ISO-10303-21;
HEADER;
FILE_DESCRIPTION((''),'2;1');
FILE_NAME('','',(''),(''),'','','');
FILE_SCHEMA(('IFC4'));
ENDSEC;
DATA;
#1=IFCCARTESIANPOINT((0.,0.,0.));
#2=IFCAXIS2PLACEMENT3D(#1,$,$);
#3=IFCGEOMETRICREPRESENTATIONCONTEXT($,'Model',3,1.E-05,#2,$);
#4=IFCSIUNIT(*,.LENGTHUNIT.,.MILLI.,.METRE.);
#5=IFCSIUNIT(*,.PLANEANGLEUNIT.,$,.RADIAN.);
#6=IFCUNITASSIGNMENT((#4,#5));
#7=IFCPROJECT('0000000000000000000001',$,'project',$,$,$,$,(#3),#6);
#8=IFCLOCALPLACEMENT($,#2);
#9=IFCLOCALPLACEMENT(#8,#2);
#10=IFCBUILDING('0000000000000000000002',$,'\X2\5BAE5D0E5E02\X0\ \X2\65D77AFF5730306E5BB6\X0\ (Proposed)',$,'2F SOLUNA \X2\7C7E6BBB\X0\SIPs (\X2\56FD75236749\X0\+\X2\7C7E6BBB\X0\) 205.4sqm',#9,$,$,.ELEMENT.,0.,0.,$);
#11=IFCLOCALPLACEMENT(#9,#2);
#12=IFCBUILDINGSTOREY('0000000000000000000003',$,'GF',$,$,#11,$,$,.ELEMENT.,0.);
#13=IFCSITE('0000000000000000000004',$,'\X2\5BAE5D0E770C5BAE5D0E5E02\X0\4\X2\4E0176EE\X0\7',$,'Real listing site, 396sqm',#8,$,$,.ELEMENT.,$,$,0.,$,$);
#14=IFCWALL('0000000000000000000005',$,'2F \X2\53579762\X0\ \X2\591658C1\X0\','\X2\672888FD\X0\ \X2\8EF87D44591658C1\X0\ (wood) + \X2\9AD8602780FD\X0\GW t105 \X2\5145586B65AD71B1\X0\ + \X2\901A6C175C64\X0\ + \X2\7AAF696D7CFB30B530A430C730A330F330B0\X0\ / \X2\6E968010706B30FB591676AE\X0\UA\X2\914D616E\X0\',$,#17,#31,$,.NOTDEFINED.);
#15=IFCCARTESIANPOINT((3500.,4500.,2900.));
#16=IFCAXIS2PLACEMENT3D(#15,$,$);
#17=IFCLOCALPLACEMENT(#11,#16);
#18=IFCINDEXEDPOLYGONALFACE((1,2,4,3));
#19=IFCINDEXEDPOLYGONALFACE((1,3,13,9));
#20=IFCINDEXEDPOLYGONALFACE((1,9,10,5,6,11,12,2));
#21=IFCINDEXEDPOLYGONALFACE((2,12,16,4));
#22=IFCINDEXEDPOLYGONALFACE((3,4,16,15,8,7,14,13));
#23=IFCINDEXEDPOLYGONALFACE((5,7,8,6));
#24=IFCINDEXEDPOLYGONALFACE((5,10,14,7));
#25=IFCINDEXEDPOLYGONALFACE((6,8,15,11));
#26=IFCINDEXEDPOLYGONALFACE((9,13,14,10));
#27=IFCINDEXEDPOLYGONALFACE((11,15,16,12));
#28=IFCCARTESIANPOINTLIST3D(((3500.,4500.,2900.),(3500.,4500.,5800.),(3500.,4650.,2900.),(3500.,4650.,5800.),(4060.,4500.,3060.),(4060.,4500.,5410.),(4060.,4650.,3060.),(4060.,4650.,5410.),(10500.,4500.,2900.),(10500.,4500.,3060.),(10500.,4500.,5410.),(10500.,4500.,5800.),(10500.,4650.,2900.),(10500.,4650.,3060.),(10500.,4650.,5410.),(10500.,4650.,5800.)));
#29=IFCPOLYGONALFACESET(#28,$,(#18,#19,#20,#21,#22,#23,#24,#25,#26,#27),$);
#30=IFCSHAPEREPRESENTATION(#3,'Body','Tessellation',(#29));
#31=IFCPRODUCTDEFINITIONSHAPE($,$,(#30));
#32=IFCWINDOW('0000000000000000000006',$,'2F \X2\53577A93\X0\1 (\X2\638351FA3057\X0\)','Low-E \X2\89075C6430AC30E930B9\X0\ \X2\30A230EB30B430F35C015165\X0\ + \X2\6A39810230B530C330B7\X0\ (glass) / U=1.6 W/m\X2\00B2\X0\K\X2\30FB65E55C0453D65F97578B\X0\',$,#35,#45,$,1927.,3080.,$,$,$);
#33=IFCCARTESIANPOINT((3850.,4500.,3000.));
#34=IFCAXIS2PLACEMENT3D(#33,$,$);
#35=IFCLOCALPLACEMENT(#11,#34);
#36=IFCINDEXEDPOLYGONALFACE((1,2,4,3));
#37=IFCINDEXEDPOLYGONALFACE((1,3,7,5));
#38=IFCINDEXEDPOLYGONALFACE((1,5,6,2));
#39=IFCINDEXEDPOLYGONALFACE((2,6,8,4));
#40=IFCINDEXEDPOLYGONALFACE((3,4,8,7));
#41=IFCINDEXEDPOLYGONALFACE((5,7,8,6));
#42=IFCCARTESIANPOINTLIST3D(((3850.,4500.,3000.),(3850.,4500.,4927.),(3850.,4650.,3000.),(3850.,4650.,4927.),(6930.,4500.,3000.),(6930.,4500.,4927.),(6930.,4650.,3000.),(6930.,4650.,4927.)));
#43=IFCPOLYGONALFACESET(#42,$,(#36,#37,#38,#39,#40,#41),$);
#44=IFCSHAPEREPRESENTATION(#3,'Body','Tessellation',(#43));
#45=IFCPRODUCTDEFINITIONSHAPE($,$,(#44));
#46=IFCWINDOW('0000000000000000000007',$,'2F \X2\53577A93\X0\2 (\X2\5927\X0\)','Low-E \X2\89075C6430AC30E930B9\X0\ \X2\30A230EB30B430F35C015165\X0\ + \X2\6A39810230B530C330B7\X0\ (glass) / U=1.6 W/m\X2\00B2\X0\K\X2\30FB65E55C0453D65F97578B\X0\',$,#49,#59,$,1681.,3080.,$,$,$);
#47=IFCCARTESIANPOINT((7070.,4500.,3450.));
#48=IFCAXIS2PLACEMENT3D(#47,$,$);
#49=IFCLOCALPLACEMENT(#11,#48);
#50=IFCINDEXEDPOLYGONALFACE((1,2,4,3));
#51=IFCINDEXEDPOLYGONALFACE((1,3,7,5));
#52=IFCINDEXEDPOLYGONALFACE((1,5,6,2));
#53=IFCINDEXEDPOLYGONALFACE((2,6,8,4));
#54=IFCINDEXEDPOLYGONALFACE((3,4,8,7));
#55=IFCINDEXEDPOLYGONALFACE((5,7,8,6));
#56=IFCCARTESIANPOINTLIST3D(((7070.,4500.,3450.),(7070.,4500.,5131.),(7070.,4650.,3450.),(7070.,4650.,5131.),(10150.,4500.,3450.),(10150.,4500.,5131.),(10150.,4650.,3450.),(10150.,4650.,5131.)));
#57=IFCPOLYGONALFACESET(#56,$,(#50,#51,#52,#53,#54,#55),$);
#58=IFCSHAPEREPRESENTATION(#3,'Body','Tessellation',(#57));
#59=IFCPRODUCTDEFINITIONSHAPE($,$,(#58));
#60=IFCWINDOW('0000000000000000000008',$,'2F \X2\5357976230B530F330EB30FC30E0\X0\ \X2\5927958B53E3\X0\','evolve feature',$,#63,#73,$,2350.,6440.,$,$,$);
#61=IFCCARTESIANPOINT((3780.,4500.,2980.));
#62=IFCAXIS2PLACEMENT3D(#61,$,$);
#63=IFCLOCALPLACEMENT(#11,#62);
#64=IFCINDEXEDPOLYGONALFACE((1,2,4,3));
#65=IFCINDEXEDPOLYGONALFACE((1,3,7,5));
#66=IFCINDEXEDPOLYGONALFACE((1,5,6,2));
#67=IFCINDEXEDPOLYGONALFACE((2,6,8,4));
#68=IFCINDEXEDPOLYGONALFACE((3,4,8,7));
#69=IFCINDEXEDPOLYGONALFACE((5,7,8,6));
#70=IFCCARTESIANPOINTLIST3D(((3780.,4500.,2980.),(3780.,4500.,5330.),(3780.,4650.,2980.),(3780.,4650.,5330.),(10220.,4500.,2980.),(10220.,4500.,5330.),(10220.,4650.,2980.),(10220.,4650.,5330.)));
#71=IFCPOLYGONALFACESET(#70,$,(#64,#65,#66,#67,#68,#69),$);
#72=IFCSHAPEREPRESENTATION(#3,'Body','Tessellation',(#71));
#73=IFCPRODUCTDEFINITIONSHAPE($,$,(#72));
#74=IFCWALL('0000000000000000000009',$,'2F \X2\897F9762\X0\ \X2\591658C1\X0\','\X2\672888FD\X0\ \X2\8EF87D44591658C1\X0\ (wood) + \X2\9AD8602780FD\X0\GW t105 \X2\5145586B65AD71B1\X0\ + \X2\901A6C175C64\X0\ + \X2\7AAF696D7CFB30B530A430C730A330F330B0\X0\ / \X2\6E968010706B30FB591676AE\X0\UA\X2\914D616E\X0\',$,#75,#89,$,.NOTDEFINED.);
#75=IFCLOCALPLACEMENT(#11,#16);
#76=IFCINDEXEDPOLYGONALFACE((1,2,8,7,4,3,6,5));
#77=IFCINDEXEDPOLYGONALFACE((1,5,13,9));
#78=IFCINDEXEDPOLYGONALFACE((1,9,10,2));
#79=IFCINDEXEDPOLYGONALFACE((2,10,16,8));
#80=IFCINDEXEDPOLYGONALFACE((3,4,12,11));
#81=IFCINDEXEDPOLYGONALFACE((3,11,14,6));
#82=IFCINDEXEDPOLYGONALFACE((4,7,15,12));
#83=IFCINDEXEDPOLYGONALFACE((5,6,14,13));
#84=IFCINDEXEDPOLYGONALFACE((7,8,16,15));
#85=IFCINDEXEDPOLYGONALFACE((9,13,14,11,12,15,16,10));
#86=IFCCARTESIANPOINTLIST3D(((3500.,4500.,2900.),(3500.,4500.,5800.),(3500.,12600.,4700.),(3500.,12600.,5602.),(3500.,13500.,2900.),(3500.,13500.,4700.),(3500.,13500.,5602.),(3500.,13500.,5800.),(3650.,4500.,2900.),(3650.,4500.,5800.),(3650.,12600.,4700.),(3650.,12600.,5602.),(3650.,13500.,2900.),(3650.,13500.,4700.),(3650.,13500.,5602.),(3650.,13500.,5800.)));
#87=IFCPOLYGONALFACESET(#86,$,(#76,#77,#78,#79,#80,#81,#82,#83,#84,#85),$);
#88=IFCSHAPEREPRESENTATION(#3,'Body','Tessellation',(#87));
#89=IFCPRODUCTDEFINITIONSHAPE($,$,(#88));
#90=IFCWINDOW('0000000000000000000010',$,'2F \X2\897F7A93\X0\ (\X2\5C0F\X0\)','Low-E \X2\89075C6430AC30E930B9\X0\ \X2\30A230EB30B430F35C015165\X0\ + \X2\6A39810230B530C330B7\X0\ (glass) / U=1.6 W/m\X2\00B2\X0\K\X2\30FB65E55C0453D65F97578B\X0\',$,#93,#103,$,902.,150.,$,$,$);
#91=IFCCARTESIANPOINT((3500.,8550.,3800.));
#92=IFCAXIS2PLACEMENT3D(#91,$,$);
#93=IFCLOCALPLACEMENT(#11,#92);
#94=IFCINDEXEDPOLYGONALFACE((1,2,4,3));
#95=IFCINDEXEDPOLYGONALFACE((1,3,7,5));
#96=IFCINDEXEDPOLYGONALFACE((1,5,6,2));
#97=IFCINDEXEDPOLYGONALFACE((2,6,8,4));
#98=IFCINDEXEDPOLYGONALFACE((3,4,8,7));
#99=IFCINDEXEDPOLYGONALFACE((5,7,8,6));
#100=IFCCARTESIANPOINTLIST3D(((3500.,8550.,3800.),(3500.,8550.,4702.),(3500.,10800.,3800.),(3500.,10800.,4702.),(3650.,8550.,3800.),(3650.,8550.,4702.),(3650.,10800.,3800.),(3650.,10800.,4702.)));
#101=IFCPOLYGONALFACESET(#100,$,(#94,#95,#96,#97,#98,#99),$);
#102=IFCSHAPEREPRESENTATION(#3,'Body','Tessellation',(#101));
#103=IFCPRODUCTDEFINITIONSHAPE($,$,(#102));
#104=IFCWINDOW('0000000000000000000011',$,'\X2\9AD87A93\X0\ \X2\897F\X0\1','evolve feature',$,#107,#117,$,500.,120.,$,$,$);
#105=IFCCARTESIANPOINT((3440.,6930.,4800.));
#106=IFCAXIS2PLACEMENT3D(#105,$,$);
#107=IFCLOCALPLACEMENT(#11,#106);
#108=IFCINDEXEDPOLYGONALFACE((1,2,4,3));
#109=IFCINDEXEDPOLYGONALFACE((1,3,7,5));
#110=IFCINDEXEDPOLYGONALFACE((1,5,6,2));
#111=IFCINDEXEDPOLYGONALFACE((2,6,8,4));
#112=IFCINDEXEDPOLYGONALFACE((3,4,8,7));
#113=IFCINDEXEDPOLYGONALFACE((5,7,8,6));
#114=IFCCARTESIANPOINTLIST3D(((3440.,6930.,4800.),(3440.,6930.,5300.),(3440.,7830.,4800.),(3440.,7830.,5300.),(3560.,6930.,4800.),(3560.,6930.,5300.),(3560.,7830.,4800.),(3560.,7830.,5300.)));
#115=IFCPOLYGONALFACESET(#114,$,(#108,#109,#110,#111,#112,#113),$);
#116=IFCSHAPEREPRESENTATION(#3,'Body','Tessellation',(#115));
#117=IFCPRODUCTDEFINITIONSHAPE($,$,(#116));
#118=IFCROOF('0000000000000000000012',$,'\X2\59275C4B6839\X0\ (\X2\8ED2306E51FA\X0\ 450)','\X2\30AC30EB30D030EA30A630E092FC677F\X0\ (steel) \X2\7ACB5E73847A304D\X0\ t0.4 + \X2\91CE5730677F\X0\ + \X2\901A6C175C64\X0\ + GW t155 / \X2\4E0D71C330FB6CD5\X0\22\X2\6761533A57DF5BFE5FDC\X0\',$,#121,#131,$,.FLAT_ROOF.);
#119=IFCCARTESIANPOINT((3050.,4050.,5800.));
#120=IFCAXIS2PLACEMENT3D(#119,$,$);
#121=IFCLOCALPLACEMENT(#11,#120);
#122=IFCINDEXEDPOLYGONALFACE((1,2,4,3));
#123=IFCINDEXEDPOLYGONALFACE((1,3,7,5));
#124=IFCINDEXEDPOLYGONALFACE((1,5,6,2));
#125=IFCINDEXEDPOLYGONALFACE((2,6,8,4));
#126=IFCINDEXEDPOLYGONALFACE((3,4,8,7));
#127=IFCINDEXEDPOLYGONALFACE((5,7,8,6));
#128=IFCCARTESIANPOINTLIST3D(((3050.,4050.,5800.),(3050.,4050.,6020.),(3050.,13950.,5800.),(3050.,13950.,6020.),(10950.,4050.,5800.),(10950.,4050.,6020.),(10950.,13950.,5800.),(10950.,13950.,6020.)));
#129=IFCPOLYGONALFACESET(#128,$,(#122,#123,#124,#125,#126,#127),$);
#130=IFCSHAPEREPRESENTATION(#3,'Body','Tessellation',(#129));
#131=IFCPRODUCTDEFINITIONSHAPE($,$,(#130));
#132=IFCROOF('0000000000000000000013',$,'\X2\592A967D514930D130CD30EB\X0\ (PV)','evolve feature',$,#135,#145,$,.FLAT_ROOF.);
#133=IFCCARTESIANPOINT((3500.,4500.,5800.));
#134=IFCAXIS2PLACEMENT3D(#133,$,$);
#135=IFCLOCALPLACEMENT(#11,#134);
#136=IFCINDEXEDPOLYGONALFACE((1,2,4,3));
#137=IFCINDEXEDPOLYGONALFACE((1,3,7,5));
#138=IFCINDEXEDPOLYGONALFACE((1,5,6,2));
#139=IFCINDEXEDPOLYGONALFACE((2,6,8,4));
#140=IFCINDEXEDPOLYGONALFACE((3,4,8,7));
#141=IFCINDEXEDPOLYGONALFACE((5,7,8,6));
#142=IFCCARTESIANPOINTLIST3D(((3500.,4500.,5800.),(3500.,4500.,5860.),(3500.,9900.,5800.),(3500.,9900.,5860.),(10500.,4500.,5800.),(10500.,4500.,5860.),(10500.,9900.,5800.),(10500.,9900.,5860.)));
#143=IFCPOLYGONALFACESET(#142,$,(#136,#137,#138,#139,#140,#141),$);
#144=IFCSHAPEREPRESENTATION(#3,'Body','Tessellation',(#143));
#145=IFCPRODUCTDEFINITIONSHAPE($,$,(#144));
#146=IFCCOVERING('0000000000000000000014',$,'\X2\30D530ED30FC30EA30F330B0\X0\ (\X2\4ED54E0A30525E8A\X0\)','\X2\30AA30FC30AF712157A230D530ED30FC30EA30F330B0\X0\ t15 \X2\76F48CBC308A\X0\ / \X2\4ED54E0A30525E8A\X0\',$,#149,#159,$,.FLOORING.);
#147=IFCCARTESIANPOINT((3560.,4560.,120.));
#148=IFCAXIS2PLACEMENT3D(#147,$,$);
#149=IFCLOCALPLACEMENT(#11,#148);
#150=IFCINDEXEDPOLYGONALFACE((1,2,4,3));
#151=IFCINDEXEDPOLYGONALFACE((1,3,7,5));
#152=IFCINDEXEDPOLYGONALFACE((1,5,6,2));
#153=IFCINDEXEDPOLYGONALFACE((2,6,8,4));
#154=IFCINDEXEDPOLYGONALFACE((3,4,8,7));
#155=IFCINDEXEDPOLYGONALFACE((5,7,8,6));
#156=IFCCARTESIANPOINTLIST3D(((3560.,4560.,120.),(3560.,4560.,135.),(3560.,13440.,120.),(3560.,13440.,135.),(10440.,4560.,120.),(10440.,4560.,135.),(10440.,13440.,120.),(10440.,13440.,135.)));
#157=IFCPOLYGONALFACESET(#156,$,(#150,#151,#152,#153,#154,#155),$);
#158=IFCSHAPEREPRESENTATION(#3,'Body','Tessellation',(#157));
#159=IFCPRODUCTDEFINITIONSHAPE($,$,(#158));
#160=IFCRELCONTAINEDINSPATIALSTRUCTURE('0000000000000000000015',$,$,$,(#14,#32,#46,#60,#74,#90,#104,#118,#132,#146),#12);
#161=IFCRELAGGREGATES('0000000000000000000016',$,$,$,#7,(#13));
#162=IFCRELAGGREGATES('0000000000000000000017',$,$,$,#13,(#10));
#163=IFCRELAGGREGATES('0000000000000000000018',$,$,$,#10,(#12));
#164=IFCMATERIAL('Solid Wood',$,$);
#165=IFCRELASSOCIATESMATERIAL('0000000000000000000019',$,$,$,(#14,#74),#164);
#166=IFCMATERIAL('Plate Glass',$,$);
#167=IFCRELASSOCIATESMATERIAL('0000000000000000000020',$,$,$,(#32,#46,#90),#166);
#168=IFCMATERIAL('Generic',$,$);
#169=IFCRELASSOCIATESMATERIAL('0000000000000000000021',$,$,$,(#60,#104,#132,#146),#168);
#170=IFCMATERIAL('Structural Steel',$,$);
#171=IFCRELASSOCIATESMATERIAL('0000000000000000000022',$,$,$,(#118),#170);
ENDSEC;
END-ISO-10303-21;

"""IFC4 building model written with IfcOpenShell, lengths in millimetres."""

from ifc_helpers import new_model, si_unit, frame, frame_2d, origin, place, context, project, spatial, rectangle, extrude, material, element, fill, save


model = new_model("IFC4")

# Units and contexts
model_context = context("Model", 3, precision=1e-05, world=origin())
ifc_project = project(units=[si_unit("LENGTHUNIT", "METRE", prefix="MILLI"), si_unit("PLANEANGLEUNIT", "RADIAN")], contexts=[model_context])

# Site, building, storey
site_placement = place(None, origin())
site = spatial("IfcSite", under=ifc_project, at=site_placement, Name="宮崎県宮崎市4丁目7", ObjectType="Real listing site, 396sqm", CompositionType="ELEMENT", RefElevation=0.0)
building_placement = place(site_placement, origin())
building = spatial("IfcBuilding", under=site, at=building_placement, Name="宮崎市 旗竿地の家 (Proposed)", ObjectType="2F SOLUNA 籾殻SIPs (国産杉+籾殻) 205.4sqm", CompositionType="ELEMENT", ElevationOfRefHeight=0.0, ElevationOfTerrain=0.0)
storey_placement = place(building_placement, origin())
storey = spatial("IfcBuildingStorey", under=building, at=storey_placement, Name="GF", CompositionType="ELEMENT", Elevation=0.0)

# Shared definitions
ifc_material_1 = material(Name="Solid Wood")

# Shared definitions
ifc_material_2 = material(Name="Plate Glass")
ifc_material_3 = material(Name="Generic")

# Walls, openings, windows
wall_1_placement = place(storey_placement, frame((3500.0, 4500.0, 2900.0)))
wall_1 = element("IfcWall", 1, at=wall_1_placement, inside=storey, material=ifc_material_1, Name="2F 南面 外壁", Description="木製 軸組外壁 (wood) + 高性能GW t105 充填断熱 + 通気層 + 窯業系サイディング / 準耐火・外皮UA配慮", PredefinedType="NOTDEFINED", context=model_context, shape_type="SweptSolid", body=[
    extrude(rectangle(XDim=7000.0, YDim=150.0, at=frame_2d((3500.0, 75.0))), frame((3500.0, 4500.0, 2900.0)), (0.0, 0.0, 1.0), 2900.0),
])
opening_1_placement = place(storey_placement, frame((3850.0, 4500.0, 3000.0)))
opening_1 = element("IfcOpeningElement", 2, at=opening_1_placement, cuts=wall_1, PredefinedType="NOTDEFINED", context=model_context, shape_type="SweptSolid", body=[
    extrude(rectangle(XDim=3080.0, YDim=150.0, at=frame_2d((1540.0, 75.0))), frame((3850.0, 4500.0, 3000.0)), (0.0, 0.0, 1.0), 1927.0),
])
opening_2_placement = place(storey_placement, frame((7070.0, 4500.0, 3450.0)))
opening_2 = element("IfcOpeningElement", 3, at=opening_2_placement, cuts=wall_1, PredefinedType="NOTDEFINED", context=model_context, shape_type="SweptSolid", body=[
    extrude(rectangle(XDim=3080.0, YDim=150.0, at=frame_2d((1540.0, 75.0))), frame((7070.0, 4500.0, 3450.0)), (0.0, 0.0, 1.0), 1681.0),
])
opening_3_placement = place(storey_placement, frame((3780.0, 4500.0, 2980.0)))
opening_3 = element("IfcOpeningElement", 4, at=opening_3_placement, cuts=wall_1, PredefinedType="NOTDEFINED", context=model_context, shape_type="SweptSolid", body=[
    extrude(rectangle(XDim=6440.0, YDim=150.0, at=frame_2d((3220.0, 75.0))), frame((3780.0, 4500.0, 2980.0)), (0.0, 0.0, 1.0), 2350.0),
])
window_1_placement = place(storey_placement, frame((3850.0, 4500.0, 3000.0)))
window_1 = element("IfcWindow", 5, at=window_1_placement, inside=storey, material=ifc_material_2, Name="2F 南窓1 (掃出し)", Description="Low-E 複層ガラス アルゴン封入 + 樹脂サッシ (glass) / U=1.6 W/m²K・日射取得型", OverallHeight=1927.0, OverallWidth=3080.0, context=model_context, shape_type="SweptSolid", body=[
    extrude(rectangle(XDim=3080.0, YDim=150.0, at=frame_2d((1540.0, 75.0))), frame((3850.0, 4500.0, 3000.0)), (0.0, 0.0, 1.0), 1927.0),
])
fill(opening_1, window_1)
window_2_placement = place(storey_placement, frame((7070.0, 4500.0, 3450.0)))
window_2 = element("IfcWindow", 6, at=window_2_placement, inside=storey, material=ifc_material_2, Name="2F 南窓2 (大)", Description="Low-E 複層ガラス アルゴン封入 + 樹脂サッシ (glass) / U=1.6 W/m²K・日射取得型", OverallHeight=1681.0, OverallWidth=3080.0, context=model_context, shape_type="SweptSolid", body=[
    extrude(rectangle(XDim=3080.0, YDim=150.0, at=frame_2d((1540.0, 75.0))), frame((7070.0, 4500.0, 3450.0)), (0.0, 0.0, 1.0), 1681.0),
])
fill(opening_2, window_2)
window_3_placement = place(storey_placement, frame((3780.0, 4500.0, 2980.0)))
window_3 = element("IfcWindow", 7, at=window_3_placement, inside=storey, material=ifc_material_3, Name="2F 南面サンルーム 大開口", Description="evolve feature", OverallHeight=2350.0, OverallWidth=6440.0, context=model_context, shape_type="SweptSolid", body=[
    extrude(rectangle(XDim=6440.0, YDim=150.0, at=frame_2d((3220.0, 75.0))), frame((3780.0, 4500.0, 2980.0)), (0.0, 0.0, 1.0), 2350.0),
])
fill(opening_3, window_3)
wall_2_placement = place(storey_placement, frame((3500.0, 4500.0, 2900.0)))
wall_2 = element("IfcWall", 8, at=wall_2_placement, inside=storey, material=ifc_material_1, Name="2F 西面 外壁", Description="木製 軸組外壁 (wood) + 高性能GW t105 充填断熱 + 通気層 + 窯業系サイディング / 準耐火・外皮UA配慮", PredefinedType="NOTDEFINED", context=model_context, shape_type="SweptSolid", body=[
    extrude(rectangle(XDim=150.0, YDim=9000.0, at=frame_2d((75.0, 4500.0))), frame((3500.0, 4500.0, 2900.0)), (0.0, 0.0, 1.0), 2900.0),
])
opening_4_placement = place(storey_placement, frame((3500.0, 8550.0, 3800.0)))
opening_4 = element("IfcOpeningElement", 9, at=opening_4_placement, cuts=wall_2, PredefinedType="NOTDEFINED", context=model_context, shape_type="SweptSolid", body=[
    extrude(rectangle(XDim=150.0, YDim=2250.0, at=frame_2d((75.0, 1125.0))), frame((3500.0, 8550.0, 3800.0)), (0.0, 0.0, 1.0), 902.0),
])
opening_5_placement = place(storey_placement, frame((3440.0, 6930.0, 4800.0)))
opening_5 = element("IfcOpeningElement", 10, at=opening_5_placement, cuts=wall_2, PredefinedType="NOTDEFINED", context=model_context, shape_type="SweptSolid", body=[
    extrude(rectangle(XDim=120.0, YDim=900.0, at=frame_2d((60.0, 450.0))), frame((3440.0, 6930.0, 4800.0)), (0.0, 0.0, 1.0), 500.0),
])
window_4_placement = place(storey_placement, frame((3500.0, 8550.0, 3800.0)))
window_4 = element("IfcWindow", 11, at=window_4_placement, inside=storey, material=ifc_material_2, Name="2F 西窓 (小)", Description="Low-E 複層ガラス アルゴン封入 + 樹脂サッシ (glass) / U=1.6 W/m²K・日射取得型", OverallHeight=902.0, OverallWidth=150.0, context=model_context, shape_type="SweptSolid", body=[
    extrude(rectangle(XDim=150.0, YDim=2250.0, at=frame_2d((75.0, 1125.0))), frame((3500.0, 8550.0, 3800.0)), (0.0, 0.0, 1.0), 902.0),
])
fill(opening_4, window_4)
window_5_placement = place(storey_placement, frame((3440.0, 6930.0, 4800.0)))
window_5 = element("IfcWindow", 12, at=window_5_placement, inside=storey, material=ifc_material_3, Name="高窓 西1", Description="evolve feature", OverallHeight=500.0, OverallWidth=120.0, context=model_context, shape_type="SweptSolid", body=[
    extrude(rectangle(XDim=120.0, YDim=900.0, at=frame_2d((60.0, 450.0))), frame((3440.0, 6930.0, 4800.0)), (0.0, 0.0, 1.0), 500.0),
])
fill(opening_5, window_5)

# Roofs
ifc_material_4 = material(Name="Structural Steel")
roof_1_placement = place(storey_placement, frame((3050.0, 4050.0, 5800.0)))
element("IfcRoof", 13, at=roof_1_placement, inside=storey, material=ifc_material_4, Name="大屋根 (軒の出 450)", Description="ガルバリウム鋼板 (steel) 立平葺き t0.4 + 野地板 + 通気層 + GW t155 / 不燃・法22条区域対応", PredefinedType="FLAT_ROOF", context=model_context, shape_type="SweptSolid", body=[
    extrude(rectangle(XDim=7900.0, YDim=9900.0, at=frame_2d((3950.0, 4950.0))), frame((3050.0, 4050.0, 5800.0)), (0.0, 0.0, 1.0), 220.0),
])
roof_2_placement = place(storey_placement, frame((3500.0, 4500.0, 5800.0)))
element("IfcRoof", 14, at=roof_2_placement, inside=storey, material=ifc_material_3, Name="太陽光パネル (PV)", Description="evolve feature", PredefinedType="FLAT_ROOF", context=model_context, shape_type="SweptSolid", body=[
    extrude(rectangle(XDim=7000.0, YDim=5400.0, at=frame_2d((3500.0, 2700.0))), frame((3500.0, 4500.0, 5800.0)), (0.0, 0.0, 1.0), 60.0),
])

# Covering
covering_placement = place(storey_placement, frame((3560.0, 4560.0, 120.0)))
element("IfcCovering", 15, at=covering_placement, inside=storey, material=ifc_material_3, Name="フローリング (仕上げ床)", Description="オーク無垢フローリング t15 直貼り / 仕上げ床", PredefinedType="FLOORING", context=model_context, shape_type="SweptSolid", body=[
    extrude(rectangle(XDim=6880.0, YDim=8880.0, at=frame_2d((3440.0, 4440.0))), frame((3560.0, 4560.0, 120.0)), (0.0, 0.0, 1.0), 15.0),
])

save(model, "model.ifc")
